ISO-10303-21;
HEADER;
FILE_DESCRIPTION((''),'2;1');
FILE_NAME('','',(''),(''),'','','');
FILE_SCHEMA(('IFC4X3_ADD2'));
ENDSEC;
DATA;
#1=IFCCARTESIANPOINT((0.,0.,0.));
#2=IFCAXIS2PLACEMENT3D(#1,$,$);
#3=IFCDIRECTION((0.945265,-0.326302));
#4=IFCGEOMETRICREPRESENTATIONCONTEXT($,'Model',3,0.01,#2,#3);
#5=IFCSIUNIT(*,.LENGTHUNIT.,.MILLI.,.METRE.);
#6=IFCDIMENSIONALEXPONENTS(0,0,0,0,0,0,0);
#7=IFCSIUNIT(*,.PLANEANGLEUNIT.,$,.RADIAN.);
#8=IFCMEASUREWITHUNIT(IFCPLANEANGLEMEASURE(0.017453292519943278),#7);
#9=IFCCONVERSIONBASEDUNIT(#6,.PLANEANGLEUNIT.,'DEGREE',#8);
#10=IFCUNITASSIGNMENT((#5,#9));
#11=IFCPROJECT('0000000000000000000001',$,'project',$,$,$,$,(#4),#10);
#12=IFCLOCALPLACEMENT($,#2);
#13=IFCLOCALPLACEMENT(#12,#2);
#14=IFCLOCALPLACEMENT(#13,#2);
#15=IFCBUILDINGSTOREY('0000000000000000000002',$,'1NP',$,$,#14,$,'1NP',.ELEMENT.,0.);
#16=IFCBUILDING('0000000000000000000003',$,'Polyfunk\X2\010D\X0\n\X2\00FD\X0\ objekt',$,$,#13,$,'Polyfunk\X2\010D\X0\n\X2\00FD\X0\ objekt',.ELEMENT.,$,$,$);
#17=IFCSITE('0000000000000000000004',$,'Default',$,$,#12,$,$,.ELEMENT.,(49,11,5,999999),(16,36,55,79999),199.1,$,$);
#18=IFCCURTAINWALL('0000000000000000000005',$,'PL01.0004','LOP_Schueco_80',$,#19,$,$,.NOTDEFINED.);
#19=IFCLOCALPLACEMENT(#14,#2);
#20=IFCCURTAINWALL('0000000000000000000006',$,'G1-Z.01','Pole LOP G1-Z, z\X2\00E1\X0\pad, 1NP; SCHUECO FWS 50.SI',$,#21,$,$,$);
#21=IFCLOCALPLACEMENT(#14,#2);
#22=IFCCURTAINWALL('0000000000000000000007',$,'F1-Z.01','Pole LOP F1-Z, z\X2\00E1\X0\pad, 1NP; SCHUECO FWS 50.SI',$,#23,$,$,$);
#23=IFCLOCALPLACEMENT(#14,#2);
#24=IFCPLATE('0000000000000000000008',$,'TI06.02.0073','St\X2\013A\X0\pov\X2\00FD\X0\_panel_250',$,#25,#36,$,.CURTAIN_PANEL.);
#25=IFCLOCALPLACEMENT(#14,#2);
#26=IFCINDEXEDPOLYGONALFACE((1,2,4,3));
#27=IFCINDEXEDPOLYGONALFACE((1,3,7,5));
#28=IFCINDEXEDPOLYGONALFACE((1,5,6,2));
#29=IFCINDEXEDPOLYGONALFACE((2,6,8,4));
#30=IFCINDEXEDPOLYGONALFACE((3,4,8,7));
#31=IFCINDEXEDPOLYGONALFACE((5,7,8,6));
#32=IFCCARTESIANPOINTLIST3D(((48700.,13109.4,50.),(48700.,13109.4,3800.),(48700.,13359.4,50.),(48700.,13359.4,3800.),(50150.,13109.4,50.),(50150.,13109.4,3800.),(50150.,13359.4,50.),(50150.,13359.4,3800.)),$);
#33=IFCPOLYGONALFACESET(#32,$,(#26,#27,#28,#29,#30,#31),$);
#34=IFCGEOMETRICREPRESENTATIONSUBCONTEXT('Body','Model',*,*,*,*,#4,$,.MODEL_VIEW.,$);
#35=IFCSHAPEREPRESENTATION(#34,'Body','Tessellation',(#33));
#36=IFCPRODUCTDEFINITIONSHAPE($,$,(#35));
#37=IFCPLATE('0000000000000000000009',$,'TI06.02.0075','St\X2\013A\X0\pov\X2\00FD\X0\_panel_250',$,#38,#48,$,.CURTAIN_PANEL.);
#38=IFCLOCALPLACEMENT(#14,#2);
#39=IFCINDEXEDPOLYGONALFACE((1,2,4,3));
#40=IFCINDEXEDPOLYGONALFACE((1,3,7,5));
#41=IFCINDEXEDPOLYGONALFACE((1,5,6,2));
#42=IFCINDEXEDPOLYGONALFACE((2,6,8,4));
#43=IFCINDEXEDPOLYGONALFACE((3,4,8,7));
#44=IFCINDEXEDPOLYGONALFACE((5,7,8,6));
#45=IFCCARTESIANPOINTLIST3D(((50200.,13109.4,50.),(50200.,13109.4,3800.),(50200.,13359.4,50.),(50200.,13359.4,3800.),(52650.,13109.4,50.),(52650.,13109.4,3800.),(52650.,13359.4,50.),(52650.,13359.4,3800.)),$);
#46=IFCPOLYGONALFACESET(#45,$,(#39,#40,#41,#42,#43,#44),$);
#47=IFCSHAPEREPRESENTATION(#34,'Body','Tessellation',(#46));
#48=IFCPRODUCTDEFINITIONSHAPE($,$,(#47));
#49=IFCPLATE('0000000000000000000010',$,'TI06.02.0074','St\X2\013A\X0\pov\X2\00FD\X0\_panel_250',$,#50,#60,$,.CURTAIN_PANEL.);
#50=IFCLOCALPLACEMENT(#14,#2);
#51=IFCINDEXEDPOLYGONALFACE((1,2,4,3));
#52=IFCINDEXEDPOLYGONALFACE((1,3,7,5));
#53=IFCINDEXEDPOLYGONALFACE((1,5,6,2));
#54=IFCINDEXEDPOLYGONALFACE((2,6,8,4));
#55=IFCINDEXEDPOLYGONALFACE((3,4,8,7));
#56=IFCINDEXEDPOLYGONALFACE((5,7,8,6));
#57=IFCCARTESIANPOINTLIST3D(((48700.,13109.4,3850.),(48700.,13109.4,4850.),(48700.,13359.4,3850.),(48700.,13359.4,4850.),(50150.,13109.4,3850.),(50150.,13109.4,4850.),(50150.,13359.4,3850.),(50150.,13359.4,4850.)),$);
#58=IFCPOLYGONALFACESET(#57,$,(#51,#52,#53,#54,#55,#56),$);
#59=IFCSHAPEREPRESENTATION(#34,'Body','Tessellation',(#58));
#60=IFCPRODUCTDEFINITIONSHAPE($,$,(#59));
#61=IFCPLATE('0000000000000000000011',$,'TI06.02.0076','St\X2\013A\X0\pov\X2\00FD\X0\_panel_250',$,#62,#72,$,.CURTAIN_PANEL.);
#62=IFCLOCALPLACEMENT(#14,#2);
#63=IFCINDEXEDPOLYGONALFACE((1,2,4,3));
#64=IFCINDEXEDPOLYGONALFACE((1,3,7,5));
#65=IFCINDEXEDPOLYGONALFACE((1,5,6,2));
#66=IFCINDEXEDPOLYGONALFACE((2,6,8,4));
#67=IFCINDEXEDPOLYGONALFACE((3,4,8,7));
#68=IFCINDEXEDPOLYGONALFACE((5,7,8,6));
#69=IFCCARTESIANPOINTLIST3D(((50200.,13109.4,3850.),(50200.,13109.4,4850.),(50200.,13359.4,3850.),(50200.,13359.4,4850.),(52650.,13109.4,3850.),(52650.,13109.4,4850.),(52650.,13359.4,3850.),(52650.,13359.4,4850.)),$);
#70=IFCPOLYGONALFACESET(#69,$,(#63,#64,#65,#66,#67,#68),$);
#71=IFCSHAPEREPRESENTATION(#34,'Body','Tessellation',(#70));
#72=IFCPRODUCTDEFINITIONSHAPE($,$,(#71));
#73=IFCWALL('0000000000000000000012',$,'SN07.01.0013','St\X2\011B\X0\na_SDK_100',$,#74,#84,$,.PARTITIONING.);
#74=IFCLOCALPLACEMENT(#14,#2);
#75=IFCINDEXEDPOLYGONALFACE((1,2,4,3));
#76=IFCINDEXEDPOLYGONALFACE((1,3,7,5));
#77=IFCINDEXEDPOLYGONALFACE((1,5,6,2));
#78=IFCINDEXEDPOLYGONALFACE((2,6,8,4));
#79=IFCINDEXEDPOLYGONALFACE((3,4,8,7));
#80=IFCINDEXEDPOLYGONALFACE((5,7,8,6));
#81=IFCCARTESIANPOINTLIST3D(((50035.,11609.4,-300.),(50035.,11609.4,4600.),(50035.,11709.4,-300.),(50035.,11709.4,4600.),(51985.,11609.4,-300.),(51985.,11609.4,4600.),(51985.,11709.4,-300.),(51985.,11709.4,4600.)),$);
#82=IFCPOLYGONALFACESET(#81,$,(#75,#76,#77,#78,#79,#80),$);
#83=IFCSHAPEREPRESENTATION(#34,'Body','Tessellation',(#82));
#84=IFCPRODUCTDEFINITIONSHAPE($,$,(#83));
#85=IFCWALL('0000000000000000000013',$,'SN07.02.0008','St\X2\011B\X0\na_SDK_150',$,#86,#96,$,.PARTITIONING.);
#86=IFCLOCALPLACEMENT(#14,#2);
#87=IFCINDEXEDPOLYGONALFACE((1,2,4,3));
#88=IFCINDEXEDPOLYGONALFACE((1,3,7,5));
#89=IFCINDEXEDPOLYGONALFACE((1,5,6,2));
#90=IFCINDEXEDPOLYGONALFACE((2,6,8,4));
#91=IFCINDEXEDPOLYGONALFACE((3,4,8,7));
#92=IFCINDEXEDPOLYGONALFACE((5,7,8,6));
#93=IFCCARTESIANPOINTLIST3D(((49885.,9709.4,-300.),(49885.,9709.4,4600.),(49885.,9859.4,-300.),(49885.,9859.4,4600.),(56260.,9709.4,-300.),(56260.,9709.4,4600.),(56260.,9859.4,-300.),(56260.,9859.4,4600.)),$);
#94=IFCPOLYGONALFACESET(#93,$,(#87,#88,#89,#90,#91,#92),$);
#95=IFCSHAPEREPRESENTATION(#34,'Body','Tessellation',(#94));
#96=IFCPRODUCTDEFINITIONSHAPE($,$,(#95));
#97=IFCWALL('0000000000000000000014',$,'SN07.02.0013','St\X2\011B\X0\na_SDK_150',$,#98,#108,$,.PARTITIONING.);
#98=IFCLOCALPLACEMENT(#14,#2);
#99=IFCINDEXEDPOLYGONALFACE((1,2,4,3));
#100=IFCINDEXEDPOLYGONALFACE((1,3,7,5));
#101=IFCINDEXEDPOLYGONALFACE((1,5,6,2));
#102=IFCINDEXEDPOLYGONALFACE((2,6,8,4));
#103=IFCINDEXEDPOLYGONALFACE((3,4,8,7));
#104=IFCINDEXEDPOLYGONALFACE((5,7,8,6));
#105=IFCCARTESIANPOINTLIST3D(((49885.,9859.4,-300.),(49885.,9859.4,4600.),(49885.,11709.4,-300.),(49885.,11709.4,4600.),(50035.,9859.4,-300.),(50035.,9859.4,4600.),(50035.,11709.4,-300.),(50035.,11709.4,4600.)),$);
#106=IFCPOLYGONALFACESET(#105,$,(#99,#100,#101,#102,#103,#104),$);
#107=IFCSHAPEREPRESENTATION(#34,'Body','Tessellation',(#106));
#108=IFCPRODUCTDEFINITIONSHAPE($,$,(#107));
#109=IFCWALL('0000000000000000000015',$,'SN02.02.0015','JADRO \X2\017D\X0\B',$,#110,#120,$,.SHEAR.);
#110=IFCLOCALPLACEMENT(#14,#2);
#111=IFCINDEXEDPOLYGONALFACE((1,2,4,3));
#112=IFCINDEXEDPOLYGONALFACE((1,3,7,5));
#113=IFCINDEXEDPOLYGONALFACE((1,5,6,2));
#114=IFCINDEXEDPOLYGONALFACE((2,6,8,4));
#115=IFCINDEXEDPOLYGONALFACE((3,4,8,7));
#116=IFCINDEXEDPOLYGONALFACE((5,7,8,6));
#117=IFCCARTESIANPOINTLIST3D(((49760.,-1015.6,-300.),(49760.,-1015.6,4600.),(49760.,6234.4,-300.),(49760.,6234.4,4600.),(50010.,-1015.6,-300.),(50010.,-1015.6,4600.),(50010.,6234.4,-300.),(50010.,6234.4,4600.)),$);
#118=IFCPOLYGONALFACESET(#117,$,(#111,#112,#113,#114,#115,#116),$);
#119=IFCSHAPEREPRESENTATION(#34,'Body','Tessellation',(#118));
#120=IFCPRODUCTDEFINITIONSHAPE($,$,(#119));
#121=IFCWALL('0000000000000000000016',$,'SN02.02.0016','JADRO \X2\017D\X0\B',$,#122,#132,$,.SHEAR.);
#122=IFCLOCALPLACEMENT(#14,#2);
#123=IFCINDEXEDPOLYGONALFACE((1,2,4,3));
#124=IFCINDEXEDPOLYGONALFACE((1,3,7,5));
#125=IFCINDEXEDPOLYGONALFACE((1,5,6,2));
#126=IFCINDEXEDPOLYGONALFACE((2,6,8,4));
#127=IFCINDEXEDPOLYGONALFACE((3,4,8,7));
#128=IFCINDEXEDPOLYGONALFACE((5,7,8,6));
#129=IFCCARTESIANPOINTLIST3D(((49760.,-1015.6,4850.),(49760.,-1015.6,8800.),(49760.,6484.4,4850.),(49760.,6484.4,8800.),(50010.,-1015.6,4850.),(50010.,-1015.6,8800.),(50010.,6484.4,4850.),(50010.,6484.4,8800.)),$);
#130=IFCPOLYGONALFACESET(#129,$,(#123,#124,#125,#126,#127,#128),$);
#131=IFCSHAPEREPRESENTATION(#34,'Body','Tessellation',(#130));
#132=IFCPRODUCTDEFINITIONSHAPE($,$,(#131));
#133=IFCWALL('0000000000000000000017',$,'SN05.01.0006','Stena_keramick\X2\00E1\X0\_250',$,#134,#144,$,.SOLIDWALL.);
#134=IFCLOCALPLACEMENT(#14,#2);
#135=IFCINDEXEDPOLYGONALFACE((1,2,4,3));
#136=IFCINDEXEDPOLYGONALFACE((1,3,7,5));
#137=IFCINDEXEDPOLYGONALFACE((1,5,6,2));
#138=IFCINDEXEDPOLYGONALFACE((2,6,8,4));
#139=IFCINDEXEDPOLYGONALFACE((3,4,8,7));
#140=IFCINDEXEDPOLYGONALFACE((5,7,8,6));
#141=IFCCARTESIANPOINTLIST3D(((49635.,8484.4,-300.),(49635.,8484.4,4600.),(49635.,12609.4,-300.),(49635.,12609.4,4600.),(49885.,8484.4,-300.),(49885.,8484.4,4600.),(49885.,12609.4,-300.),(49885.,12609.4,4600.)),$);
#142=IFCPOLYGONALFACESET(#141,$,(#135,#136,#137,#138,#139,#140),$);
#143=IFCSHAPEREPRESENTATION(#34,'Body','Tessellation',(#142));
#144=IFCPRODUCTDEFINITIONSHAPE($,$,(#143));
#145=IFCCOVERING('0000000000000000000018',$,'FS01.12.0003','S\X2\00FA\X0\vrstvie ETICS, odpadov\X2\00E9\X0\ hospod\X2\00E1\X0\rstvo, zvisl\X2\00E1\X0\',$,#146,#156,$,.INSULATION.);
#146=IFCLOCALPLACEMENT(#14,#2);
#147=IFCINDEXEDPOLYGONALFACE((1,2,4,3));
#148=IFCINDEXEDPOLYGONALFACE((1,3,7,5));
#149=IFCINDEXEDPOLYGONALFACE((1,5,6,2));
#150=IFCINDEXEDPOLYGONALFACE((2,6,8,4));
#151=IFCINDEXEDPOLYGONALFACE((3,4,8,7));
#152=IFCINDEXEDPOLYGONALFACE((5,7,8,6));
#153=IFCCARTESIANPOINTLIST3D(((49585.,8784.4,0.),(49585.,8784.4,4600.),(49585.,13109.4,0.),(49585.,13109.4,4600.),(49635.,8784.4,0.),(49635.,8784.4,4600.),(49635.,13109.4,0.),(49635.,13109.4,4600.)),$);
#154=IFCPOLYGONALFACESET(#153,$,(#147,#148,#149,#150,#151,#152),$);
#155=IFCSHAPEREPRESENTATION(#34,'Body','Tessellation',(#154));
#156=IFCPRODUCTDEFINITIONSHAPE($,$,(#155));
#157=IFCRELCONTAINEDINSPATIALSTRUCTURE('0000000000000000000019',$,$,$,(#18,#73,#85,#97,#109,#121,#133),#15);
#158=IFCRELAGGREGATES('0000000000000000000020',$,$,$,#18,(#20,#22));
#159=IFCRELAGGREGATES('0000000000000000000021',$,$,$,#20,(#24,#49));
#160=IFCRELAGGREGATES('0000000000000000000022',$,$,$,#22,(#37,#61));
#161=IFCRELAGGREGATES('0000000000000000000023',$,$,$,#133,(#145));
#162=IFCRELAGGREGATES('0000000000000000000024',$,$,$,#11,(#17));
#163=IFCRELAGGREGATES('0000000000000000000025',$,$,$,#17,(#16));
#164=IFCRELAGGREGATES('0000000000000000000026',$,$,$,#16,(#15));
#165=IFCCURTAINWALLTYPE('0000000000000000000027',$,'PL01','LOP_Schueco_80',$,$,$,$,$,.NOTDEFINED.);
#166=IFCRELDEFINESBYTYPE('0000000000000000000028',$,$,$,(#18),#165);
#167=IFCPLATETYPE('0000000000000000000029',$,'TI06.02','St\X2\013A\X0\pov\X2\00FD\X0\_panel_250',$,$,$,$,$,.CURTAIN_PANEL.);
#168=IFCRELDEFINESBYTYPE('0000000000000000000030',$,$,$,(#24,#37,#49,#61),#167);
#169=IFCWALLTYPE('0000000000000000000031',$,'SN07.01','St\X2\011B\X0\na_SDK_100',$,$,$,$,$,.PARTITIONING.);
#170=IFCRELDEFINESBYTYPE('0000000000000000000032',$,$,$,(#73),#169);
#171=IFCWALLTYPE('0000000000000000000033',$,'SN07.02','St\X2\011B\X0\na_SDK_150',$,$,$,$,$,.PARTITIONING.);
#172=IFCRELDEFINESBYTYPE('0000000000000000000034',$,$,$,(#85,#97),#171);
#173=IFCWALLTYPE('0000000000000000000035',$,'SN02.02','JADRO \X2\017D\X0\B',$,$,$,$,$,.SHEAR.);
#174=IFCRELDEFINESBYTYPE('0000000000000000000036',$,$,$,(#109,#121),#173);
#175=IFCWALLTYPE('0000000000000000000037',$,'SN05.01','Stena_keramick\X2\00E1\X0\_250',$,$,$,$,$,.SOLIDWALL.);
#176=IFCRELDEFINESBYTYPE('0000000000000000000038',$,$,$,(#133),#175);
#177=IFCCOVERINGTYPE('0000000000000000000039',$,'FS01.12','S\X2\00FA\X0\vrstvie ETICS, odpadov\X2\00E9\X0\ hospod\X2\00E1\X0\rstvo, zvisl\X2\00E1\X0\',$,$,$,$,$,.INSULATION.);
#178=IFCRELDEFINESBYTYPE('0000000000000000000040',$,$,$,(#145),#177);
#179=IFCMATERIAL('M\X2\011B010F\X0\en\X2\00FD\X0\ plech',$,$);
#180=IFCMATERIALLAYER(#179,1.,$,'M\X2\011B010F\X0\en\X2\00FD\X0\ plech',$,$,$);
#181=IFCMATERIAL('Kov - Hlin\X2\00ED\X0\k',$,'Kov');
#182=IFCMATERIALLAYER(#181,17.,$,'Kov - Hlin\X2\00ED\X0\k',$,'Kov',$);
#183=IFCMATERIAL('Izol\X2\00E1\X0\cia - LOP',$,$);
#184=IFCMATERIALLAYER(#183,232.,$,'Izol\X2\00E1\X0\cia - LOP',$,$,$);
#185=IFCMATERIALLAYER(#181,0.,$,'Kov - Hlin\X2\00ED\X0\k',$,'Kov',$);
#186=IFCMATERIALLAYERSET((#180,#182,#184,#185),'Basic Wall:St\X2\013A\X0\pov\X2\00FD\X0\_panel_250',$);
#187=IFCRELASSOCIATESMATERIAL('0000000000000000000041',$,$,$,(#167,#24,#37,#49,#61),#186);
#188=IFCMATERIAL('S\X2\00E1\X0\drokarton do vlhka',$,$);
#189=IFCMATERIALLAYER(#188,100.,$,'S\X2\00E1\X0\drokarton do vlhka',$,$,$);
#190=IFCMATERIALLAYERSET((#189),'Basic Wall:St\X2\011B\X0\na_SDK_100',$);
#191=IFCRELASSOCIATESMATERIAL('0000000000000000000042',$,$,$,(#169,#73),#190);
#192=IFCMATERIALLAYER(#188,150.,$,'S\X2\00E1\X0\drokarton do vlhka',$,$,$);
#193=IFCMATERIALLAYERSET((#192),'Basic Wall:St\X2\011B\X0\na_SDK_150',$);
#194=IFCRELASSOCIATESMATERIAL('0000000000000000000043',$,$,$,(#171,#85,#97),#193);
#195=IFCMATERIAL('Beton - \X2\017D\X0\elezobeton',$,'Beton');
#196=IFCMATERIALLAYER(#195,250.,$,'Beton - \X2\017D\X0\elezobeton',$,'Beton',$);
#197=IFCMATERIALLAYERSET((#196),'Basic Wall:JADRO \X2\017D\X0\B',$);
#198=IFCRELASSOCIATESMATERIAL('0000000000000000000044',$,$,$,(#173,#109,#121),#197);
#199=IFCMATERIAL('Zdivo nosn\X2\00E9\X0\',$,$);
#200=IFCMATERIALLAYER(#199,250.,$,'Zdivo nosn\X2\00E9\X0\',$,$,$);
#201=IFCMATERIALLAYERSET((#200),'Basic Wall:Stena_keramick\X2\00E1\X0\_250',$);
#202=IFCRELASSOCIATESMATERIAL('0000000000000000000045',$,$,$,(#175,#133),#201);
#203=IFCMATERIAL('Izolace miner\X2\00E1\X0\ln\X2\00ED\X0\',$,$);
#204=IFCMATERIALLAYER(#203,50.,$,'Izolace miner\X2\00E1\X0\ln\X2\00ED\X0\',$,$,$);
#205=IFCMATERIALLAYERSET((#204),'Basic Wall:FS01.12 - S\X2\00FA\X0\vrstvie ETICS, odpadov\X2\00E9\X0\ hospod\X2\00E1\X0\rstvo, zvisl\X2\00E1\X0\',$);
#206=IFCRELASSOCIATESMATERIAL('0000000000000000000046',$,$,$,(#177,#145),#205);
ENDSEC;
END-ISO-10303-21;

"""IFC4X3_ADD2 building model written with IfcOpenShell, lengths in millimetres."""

from ifc_helpers import new_model, entity, si_unit, converted_unit, direction, frame, frame_2d, origin, origin_2d_with_axis, place, context, subcontext, project, spatial, polyline, rectangle, extrude, clip, bounded_halfspace, material, layer, layer_set, layer_usage, type_object, element, aggregate, save


model = new_model("IFC4X3_ADD2")

# Units and contexts
model_context = context("Model", 3, precision=0.01, world=origin(), true_north=direction((0.945265, -0.326302)))
body_context = subcontext(model_context, "Body", "Model", "MODEL_VIEW")
ifc_project = project(units=[si_unit("LENGTHUNIT", "METRE", prefix="MILLI"), converted_unit("PLANEANGLEUNIT", "DEGREE", entity("IfcPlaneAngleMeasure", 0.017453292519943278), si_unit("PLANEANGLEUNIT", "RADIAN"), dimensions=[0, 0, 0, 0, 0, 0, 0])], contexts=[model_context])

# Site, building, storey
site_placement = place(None, origin())
site = spatial("IfcSite", under=ifc_project, at=site_placement, Name="Default", CompositionType="ELEMENT", RefLatitude=(49, 11, 5, 999999), RefLongitude=(16, 36, 55, 79999), RefElevation=199.1)
building_placement = place(site_placement, origin())
building = spatial("IfcBuilding", under=site, at=building_placement, Name="Polyfunkčný objekt", LongName="Polyfunkčný objekt", CompositionType="ELEMENT")
storey_placement = place(building_placement, origin())
storey = spatial("IfcBuildingStorey", under=building, at=storey_placement, Name="1NP", LongName="1NP", CompositionType="ELEMENT", Elevation=0.0)

# Curtain walls, plates
curtain_wall_type = type_object("IfcCurtainWallType", Name="PL01", Description="LOP_Schueco_80", PredefinedType="NOTDEFINED")
curtain_wall_1_placement = place(storey_placement, origin())
curtain_wall_1 = element("IfcCurtainWall", 1, at=curtain_wall_1_placement, inside=storey, type_object=curtain_wall_type, Name="PL01.0004", Description="LOP_Schueco_80", PredefinedType="NOTDEFINED")
curtain_wall_2 = element("IfcCurtainWall", 2, Name="G1-Z.01", Description="Pole LOP G1-Z, západ, 1NP; SCHUECO FWS 50.SI")
curtain_wall_3 = element("IfcCurtainWall", 3, Name="F1-Z.01", Description="Pole LOP F1-Z, západ, 1NP; SCHUECO FWS 50.SI")
aggregate(curtain_wall_1, [curtain_wall_2, curtain_wall_3])
ifc_material_1 = material(Name="Měďený plech")
ifc_layer_1 = layer(ifc_material_1, 1.0, Name="Měďený plech")
ifc_material_2 = material(Name="Kov - Hliník", Category="Kov")
ifc_layer_2 = layer(ifc_material_2, 17.0, Name="Kov - Hliník", Category="Kov")
ifc_material_3 = material(Name="Izolácia - LOP")
ifc_layer_3 = layer(ifc_material_3, 232.0, Name="Izolácia - LOP")
ifc_layer_4 = layer(ifc_material_2, 0.0, Name="Kov - Hliník", Category="Kov")
ifc_layer_set_1 = layer_set([ifc_layer_1, ifc_layer_2, ifc_layer_3, ifc_layer_4], Name="Basic Wall:Stĺpový_panel_250")
ifc_layer_usage_1 = layer_usage(ifc_layer_set_1, "AXIS2", "NEGATIVE", 125.0)
plate_type = type_object("IfcPlateType", Name="TI06.02", Description="Stĺpový_panel_250", PredefinedType="CURTAIN_PANEL", material=ifc_layer_set_1)
plate_1_placement = place(storey_placement, frame((48700.0, 13234.4, 50.0)))
plate_1 = element("IfcPlate", 4, at=plate_1_placement, type_object=plate_type, material=ifc_layer_usage_1, Name="TI06.02.0073", Description="Stĺpový_panel_250", PredefinedType="CURTAIN_PANEL", context=body_context, shape_type="SweptSolid", body=[
    extrude(rectangle(XDim=250.0, YDim=1450.0, at=frame_2d((0.0, 0.0), x_axis=(1.0, 0.0))), frame((725.0, 0.0, 0.0), z_axis=(0.0, 0.0, 1.0), x_axis=(0.0, 1.0, 0.0)), (0.0, 0.0, 1.0), 3750.0),
])
ifc_layer_usage_2 = layer_usage(ifc_layer_set_1, "AXIS2", "NEGATIVE", 125.0)
plate_2_placement = place(storey_placement, frame((50200.0, 13234.4, 50.0)))
plate_2 = element("IfcPlate", 5, at=plate_2_placement, type_object=plate_type, material=ifc_layer_usage_2, Name="TI06.02.0075", Description="Stĺpový_panel_250", PredefinedType="CURTAIN_PANEL", context=body_context, shape_type="SweptSolid", body=[
    extrude(rectangle(XDim=250.0, YDim=2450.0, at=origin_2d_with_axis()), frame((1225.0, 0.0, 0.0), z_axis=(0.0, 0.0, 1.0), x_axis=(0.0, 1.0, 0.0)), (0.0, 0.0, 1.0), 3750.0),
])
ifc_layer_usage_3 = layer_usage(ifc_layer_set_1, "AXIS2", "NEGATIVE", 125.0)
plate_3_placement = place(storey_placement, frame((48700.0, 13234.4, 3850.0)))
plate_3 = element("IfcPlate", 6, at=plate_3_placement, type_object=plate_type, material=ifc_layer_usage_3, Name="TI06.02.0074", Description="Stĺpový_panel_250", PredefinedType="CURTAIN_PANEL", context=body_context, shape_type="SweptSolid", body=[
    extrude(rectangle(XDim=250.0, YDim=1450.0, at=frame_2d((0.0, 0.0), x_axis=(1.0, 0.0))), frame((725.0, 0.0, 0.0), z_axis=(0.0, 0.0, 1.0), x_axis=(0.0, 1.0, 0.0)), (0.0, 0.0, 1.0), 1000.0),
])
aggregate(curtain_wall_2, [plate_1, plate_3])
ifc_layer_usage_4 = layer_usage(ifc_layer_set_1, "AXIS2", "NEGATIVE", 125.0)
plate_4_placement = place(storey_placement, frame((50200.0, 13234.4, 3850.0)))
plate_4 = element("IfcPlate", 7, at=plate_4_placement, type_object=plate_type, material=ifc_layer_usage_4, Name="TI06.02.0076", Description="Stĺpový_panel_250", PredefinedType="CURTAIN_PANEL", context=body_context, shape_type="SweptSolid", body=[
    extrude(rectangle(XDim=250.0, YDim=2450.0, at=origin_2d_with_axis()), frame((1225.0, 0.0, 0.0), z_axis=(0.0, 0.0, 1.0), x_axis=(0.0, 1.0, 0.0)), (0.0, 0.0, 1.0), 1000.0),
])
aggregate(curtain_wall_3, [plate_2, plate_4])

# Walls
ifc_material_4 = material(Name="Sádrokarton do vlhka")
ifc_layer_5 = layer(ifc_material_4, 100.0, Name="Sádrokarton do vlhka")
ifc_layer_set_2 = layer_set([ifc_layer_5], Name="Basic Wall:Stěna_SDK_100")
wall_type_1 = type_object("IfcWallType", Name="SN07.01", Description="Stěna_SDK_100", PredefinedType="PARTITIONING", material=ifc_layer_set_2)
wall_1_placement = place(storey_placement, frame((51985.0, 11659.4, -300.0), z_axis=(0.0, 0.0, 1.0), x_axis=(-1.0, 0.0, 0.0)))
element("IfcWall", 8, at=wall_1_placement, inside=storey, type_object=wall_type_1, material=ifc_layer_set_2, Name="SN07.01.0013", Description="Stěna_SDK_100", PredefinedType="PARTITIONING", context=body_context, shape_type="Clipping", body=[
    clip(clip(extrude(rectangle(XDim=1950.0, YDim=100.0, at=frame_2d((975.0, 0.0), x_axis=(-1.0, 0.0))), origin(), (0.0, 0.0, 1.0), 4900.0), bounded_halfspace(frame((0.0, -50.0, 4900.0), z_axis=(0.0, 0.0, -1.0), x_axis=(-1.0, 0.0, 0.0)), True, frame((0.0, -50.0, 4900.0)), polyline([(0.0, 0.0), (1950.0, 0.0), (1950.0, 100.0), (1050.0, 100.0), (900.0, 100.0), (0.0, 100.0), (0.0, 0.0)]))), bounded_halfspace(frame((1950.0, -50.0, 0.0), z_axis=(0.0, 0.0, 1.0), x_axis=(0.0, -1.0, 0.0)), True, frame((1950.0, -50.0, 0.0)), polyline([(0.0, 0.0), (0.0, 100.0), (-900.0, 100.0), (-1050.0, 100.0), (-1950.0, 100.0), (-1950.0, 0.0), (0.0, 0.0)]))),
])
ifc_layer_6 = layer(ifc_material_4, 150.0, Name="Sádrokarton do vlhka")
ifc_layer_set_3 = layer_set([ifc_layer_6], Name="Basic Wall:Stěna_SDK_150")
wall_type_2 = type_object("IfcWallType", Name="SN07.02", Description="Stěna_SDK_150", PredefinedType="PARTITIONING", material=ifc_layer_set_3)
wall_2_placement = place(storey_placement, frame((49885.0, 9784.4, -300.0)))
element("IfcWall", 9, at=wall_2_placement, inside=storey, type_object=wall_type_2, material=ifc_layer_set_3, Name="SN07.02.0008", Description="Stěna_SDK_150", PredefinedType="PARTITIONING", context=body_context, shape_type="Clipping", body=[
    clip(clip(extrude(rectangle(XDim=6375.0, YDim=150.0, at=frame_2d((3187.5, 0.0), x_axis=(-1.0, 0.0))), origin(), (0.0, 0.0, 1.0), 4900.0), bounded_halfspace(frame((0.0, -75.0, 4900.0), z_axis=(0.0, 0.0, -1.0), x_axis=(1.0, 0.0, 0.0)), True, frame((0.0, -75.0, 4900.0)), polyline([(0.0, 0.0), (6375.0, 0.0), (6375.0, 150.0), (2250.0, 150.0), (2100.0, 150.0), (1200.0, 150.0), (1050.0, 150.0), (150.0, 150.0), (0.0, 150.0), (0.0, 0.0)]))), bounded_halfspace(frame((6375.0, -75.0, 0.0), z_axis=(0.0, 0.0, 1.0), x_axis=(0.0, 1.0, 0.0)), True, frame((6375.0, -75.0, 0.0)), polyline([(0.0, 0.0), (0.0, 150.0), (-4125.0, 150.0), (-4275.0, 150.0), (-5175.0, 150.0), (-5325.0, 150.0), (-6225.0, 150.0), (-6375.0, 150.0), (-6375.0, 0.0), (0.0, 0.0)]))),
])
wall_3_placement = place(storey_placement, frame((49960.0, 9859.4, -300.0), z_axis=(0.0, 0.0, 1.0), x_axis=(0.0, 1.0, 0.0)))
element("IfcWall", 10, at=wall_3_placement, inside=storey, type_object=wall_type_2, material=ifc_layer_set_3, Name="SN07.02.0013", Description="Stěna_SDK_150", PredefinedType="PARTITIONING", context=body_context, shape_type="Clipping", body=[
    clip(clip(extrude(rectangle(XDim=1850.0, YDim=150.0, at=frame_2d((925.0, 0.0), x_axis=(-1.0, 0.0))), origin(), (0.0, 0.0, 1.0), 4900.0), bounded_halfspace(frame((0.0, -75.0, 4900.0), z_axis=(0.0, 0.0, -1.0), x_axis=(0.0, -1.0, 0.0)), True, frame((0.0, -75.0, 4900.0)), polyline([(0.0, 0.0), (1750.0, 0.0), (1850.0, 0.0), (1850.0, 150.0), (0.0, 150.0), (0.0, 0.0)]))), bounded_halfspace(frame((1850.0, -75.0, 0.0)), True, frame((1850.0, -75.0, 0.0)), polyline([(0.0, 0.0), (0.0, 150.0), (-1850.0, 150.0), (-1850.0, 0.0), (-100.0, 0.0), (0.0, 0.0)]))),
])
ifc_material_5 = material(Name="Beton - Železobeton", Category="Beton")
ifc_layer_7 = layer(ifc_material_5, 250.0, Name="Beton - Železobeton", Category="Beton")
ifc_layer_set_4 = layer_set([ifc_layer_7], Name="Basic Wall:JADRO ŽB")
wall_type_3 = type_object("IfcWallType", Name="SN02.02", Description="JADRO ŽB", PredefinedType="SHEAR", material=ifc_layer_set_4)
wall_4_placement = place(storey_placement, frame((49885.0, 6234.4, -300.0), z_axis=(0.0, 0.0, 1.0), x_axis=(0.0, -1.0, 0.0)))
element("IfcWall", 11, at=wall_4_placement, inside=storey, type_object=wall_type_3, material=ifc_layer_set_4, Name="SN02.02.0015", Description="JADRO ŽB", PredefinedType="SHEAR", context=body_context, shape_type="Clipping", body=[
    clip(clip(extrude(rectangle(XDim=7250.0, YDim=250.0, at=frame_2d((3625.0, 0.0), x_axis=(-1.0, 0.0))), origin(), (0.0, 0.0, 1.0), 4900.0), bounded_halfspace(frame((0.0, -125.0, 4900.0), z_axis=(0.0, 0.0, -1.0), x_axis=(0.0, 1.0, 0.0)), True, frame((0.0, -125.0, 4900.0)), polyline([(0.0, 0.0), (800.0, 0.0), (950.0, 0.0), (7250.0, 0.0), (7250.0, 250.0), (0.0, 250.0), (0.0, 0.0)]))), bounded_halfspace(frame((7250.0, -125.0, 0.0), z_axis=(0.0, 0.0, 1.0), x_axis=(-1.0, 0.0, 0.0)), True, frame((7250.0, -125.0, 0.0)), polyline([(0.0, 0.0), (0.0, 250.0), (-7250.0, 250.0), (-7250.0, 0.0), (-6450.0, 0.0), (-6300.0, 0.0), (0.0, 0.0)]))),
])
wall_5_placement = place(storey_placement, frame((49885.0, 6484.4, 4850.0), z_axis=(0.0, 0.0, 1.0), x_axis=(0.0, -1.0, 0.0)))
element("IfcWall", 12, at=wall_5_placement, inside=storey, type_object=wall_type_3, material=ifc_layer_set_4, Name="SN02.02.0016", Description="JADRO ŽB", PredefinedType="SHEAR", context=body_context, shape_type="Clipping", body=[
    clip(clip(extrude(rectangle(XDim=7500.0, YDim=250.0, at=frame_2d((3750.0, 0.0), x_axis=(-1.0, 0.0))), origin(), (0.0, 0.0, 1.0), 3950.0), bounded_halfspace(frame((7500.0, -125.0, 0.0), z_axis=(0.0, 0.0, 1.0), x_axis=(0.0, -1.0, 0.0)), True, frame((7500.0, -125.0, 0.0)), polyline([(0.0, 0.0), (0.0, 250.0), (-7500.0, 250.0), (-7500.0, 0.0), (-7250.0, 0.0), (-6450.0, 0.0), (-6300.0, 0.0), (0.0, 0.0)]))), bounded_halfspace(frame((0.0, -125.0, 3950.0), z_axis=(0.0, 0.0, -1.0), x_axis=(0.0, 1.0, 0.0)), True, frame((0.0, -125.0, 3950.0)), polyline([(0.0, 0.0), (250.0, 0.0), (1050.0, 0.0), (1200.0, 0.0), (7500.0, 0.0), (7500.0, 250.0), (0.0, 250.0), (0.0, 0.0)]))),
])

# Wall
ifc_material_6 = material(Name="Zdivo nosné")
ifc_layer_8 = layer(ifc_material_6, 250.0, Name="Zdivo nosné")
ifc_layer_set_5 = layer_set([ifc_layer_8], Name="Basic Wall:Stena_keramická_250")
wall_type_4 = type_object("IfcWallType", Name="SN05.01", Description="Stena_keramická_250", PredefinedType="SOLIDWALL", material=ifc_layer_set_5)
wall_6_placement = place(storey_placement, frame((49760.0, 12609.4, -300.0), z_axis=(0.0, 0.0, 1.0), x_axis=(0.0, -1.0, 0.0)))
wall_6 = element("IfcWall", 13, at=wall_6_placement, inside=storey, type_object=wall_type_4, material=ifc_layer_set_5, Name="SN05.01.0006", Description="Stena_keramická_250", PredefinedType="SOLIDWALL", context=body_context, shape_type="Clipping", body=[
    clip(clip(extrude(rectangle(XDim=4125.0, YDim=250.0, at=frame_2d((2062.5, 0.0), x_axis=(-1.0, 0.0))), origin(), (0.0, 0.0, 1.0), 4900.0), bounded_halfspace(frame((0.0, -125.0, 4900.0), z_axis=(0.0, 0.0, -1.0), x_axis=(0.0, 1.0, 0.0)), True, frame((0.0, -125.0, 4900.0)), polyline([(0.0, 0.0), (3875.0, 0.0), (4125.0, 0.0), (4125.0, 250.0), (0.0, 250.0), (0.0, 0.0)]))), bounded_halfspace(frame((4125.0, -125.0, 0.0), z_axis=(0.0, 0.0, 1.0), x_axis=(-1.0, 0.0, 0.0)), True, frame((4125.0, -125.0, 0.0)), polyline([(0.0, 0.0), (0.0, 250.0), (-4125.0, 250.0), (-4125.0, 0.0), (-250.0, 0.0), (0.0, 0.0)]))),
])

# Covering
ifc_material_7 = material(Name="Izolace minerální")
ifc_layer_9 = layer(ifc_material_7, 50.0, Name="Izolace minerální")
ifc_layer_set_6 = layer_set([ifc_layer_9], Name="Basic Wall:FS01.12 - Súvrstvie ETICS, odpadové hospodárstvo, zvislá")
covering_type_1 = type_object("IfcCoveringType", Name="FS01.12", Description="Súvrstvie ETICS, odpadové hospodárstvo, zvislá", PredefinedType="INSULATION", material=ifc_layer_set_6)
covering_1_placement = place(storey_placement, frame((49610.0, 8784.4, 0.0), z_axis=(0.0, 0.0, 1.0), x_axis=(0.0, 1.0, 0.0)))
covering_1 = element("IfcCovering", 14, at=covering_1_placement, type_object=covering_type_1, material=ifc_layer_set_6, Name="FS01.12.0003", Description="Súvrstvie ETICS, odpadové hospodárstvo, zvislá", PredefinedType="INSULATION", context=body_context, shape_type="SweptSolid", body=[
    extrude(rectangle(XDim=4325.0, YDim=50.0, at=frame_2d((2162.5, 0.0), x_axis=(-1.0, 0.0))), origin(), (0.0, 0.0, 1.0), 4600.0),
])
aggregate(wall_6, [covering_1])

save(model, "model.ifc")
